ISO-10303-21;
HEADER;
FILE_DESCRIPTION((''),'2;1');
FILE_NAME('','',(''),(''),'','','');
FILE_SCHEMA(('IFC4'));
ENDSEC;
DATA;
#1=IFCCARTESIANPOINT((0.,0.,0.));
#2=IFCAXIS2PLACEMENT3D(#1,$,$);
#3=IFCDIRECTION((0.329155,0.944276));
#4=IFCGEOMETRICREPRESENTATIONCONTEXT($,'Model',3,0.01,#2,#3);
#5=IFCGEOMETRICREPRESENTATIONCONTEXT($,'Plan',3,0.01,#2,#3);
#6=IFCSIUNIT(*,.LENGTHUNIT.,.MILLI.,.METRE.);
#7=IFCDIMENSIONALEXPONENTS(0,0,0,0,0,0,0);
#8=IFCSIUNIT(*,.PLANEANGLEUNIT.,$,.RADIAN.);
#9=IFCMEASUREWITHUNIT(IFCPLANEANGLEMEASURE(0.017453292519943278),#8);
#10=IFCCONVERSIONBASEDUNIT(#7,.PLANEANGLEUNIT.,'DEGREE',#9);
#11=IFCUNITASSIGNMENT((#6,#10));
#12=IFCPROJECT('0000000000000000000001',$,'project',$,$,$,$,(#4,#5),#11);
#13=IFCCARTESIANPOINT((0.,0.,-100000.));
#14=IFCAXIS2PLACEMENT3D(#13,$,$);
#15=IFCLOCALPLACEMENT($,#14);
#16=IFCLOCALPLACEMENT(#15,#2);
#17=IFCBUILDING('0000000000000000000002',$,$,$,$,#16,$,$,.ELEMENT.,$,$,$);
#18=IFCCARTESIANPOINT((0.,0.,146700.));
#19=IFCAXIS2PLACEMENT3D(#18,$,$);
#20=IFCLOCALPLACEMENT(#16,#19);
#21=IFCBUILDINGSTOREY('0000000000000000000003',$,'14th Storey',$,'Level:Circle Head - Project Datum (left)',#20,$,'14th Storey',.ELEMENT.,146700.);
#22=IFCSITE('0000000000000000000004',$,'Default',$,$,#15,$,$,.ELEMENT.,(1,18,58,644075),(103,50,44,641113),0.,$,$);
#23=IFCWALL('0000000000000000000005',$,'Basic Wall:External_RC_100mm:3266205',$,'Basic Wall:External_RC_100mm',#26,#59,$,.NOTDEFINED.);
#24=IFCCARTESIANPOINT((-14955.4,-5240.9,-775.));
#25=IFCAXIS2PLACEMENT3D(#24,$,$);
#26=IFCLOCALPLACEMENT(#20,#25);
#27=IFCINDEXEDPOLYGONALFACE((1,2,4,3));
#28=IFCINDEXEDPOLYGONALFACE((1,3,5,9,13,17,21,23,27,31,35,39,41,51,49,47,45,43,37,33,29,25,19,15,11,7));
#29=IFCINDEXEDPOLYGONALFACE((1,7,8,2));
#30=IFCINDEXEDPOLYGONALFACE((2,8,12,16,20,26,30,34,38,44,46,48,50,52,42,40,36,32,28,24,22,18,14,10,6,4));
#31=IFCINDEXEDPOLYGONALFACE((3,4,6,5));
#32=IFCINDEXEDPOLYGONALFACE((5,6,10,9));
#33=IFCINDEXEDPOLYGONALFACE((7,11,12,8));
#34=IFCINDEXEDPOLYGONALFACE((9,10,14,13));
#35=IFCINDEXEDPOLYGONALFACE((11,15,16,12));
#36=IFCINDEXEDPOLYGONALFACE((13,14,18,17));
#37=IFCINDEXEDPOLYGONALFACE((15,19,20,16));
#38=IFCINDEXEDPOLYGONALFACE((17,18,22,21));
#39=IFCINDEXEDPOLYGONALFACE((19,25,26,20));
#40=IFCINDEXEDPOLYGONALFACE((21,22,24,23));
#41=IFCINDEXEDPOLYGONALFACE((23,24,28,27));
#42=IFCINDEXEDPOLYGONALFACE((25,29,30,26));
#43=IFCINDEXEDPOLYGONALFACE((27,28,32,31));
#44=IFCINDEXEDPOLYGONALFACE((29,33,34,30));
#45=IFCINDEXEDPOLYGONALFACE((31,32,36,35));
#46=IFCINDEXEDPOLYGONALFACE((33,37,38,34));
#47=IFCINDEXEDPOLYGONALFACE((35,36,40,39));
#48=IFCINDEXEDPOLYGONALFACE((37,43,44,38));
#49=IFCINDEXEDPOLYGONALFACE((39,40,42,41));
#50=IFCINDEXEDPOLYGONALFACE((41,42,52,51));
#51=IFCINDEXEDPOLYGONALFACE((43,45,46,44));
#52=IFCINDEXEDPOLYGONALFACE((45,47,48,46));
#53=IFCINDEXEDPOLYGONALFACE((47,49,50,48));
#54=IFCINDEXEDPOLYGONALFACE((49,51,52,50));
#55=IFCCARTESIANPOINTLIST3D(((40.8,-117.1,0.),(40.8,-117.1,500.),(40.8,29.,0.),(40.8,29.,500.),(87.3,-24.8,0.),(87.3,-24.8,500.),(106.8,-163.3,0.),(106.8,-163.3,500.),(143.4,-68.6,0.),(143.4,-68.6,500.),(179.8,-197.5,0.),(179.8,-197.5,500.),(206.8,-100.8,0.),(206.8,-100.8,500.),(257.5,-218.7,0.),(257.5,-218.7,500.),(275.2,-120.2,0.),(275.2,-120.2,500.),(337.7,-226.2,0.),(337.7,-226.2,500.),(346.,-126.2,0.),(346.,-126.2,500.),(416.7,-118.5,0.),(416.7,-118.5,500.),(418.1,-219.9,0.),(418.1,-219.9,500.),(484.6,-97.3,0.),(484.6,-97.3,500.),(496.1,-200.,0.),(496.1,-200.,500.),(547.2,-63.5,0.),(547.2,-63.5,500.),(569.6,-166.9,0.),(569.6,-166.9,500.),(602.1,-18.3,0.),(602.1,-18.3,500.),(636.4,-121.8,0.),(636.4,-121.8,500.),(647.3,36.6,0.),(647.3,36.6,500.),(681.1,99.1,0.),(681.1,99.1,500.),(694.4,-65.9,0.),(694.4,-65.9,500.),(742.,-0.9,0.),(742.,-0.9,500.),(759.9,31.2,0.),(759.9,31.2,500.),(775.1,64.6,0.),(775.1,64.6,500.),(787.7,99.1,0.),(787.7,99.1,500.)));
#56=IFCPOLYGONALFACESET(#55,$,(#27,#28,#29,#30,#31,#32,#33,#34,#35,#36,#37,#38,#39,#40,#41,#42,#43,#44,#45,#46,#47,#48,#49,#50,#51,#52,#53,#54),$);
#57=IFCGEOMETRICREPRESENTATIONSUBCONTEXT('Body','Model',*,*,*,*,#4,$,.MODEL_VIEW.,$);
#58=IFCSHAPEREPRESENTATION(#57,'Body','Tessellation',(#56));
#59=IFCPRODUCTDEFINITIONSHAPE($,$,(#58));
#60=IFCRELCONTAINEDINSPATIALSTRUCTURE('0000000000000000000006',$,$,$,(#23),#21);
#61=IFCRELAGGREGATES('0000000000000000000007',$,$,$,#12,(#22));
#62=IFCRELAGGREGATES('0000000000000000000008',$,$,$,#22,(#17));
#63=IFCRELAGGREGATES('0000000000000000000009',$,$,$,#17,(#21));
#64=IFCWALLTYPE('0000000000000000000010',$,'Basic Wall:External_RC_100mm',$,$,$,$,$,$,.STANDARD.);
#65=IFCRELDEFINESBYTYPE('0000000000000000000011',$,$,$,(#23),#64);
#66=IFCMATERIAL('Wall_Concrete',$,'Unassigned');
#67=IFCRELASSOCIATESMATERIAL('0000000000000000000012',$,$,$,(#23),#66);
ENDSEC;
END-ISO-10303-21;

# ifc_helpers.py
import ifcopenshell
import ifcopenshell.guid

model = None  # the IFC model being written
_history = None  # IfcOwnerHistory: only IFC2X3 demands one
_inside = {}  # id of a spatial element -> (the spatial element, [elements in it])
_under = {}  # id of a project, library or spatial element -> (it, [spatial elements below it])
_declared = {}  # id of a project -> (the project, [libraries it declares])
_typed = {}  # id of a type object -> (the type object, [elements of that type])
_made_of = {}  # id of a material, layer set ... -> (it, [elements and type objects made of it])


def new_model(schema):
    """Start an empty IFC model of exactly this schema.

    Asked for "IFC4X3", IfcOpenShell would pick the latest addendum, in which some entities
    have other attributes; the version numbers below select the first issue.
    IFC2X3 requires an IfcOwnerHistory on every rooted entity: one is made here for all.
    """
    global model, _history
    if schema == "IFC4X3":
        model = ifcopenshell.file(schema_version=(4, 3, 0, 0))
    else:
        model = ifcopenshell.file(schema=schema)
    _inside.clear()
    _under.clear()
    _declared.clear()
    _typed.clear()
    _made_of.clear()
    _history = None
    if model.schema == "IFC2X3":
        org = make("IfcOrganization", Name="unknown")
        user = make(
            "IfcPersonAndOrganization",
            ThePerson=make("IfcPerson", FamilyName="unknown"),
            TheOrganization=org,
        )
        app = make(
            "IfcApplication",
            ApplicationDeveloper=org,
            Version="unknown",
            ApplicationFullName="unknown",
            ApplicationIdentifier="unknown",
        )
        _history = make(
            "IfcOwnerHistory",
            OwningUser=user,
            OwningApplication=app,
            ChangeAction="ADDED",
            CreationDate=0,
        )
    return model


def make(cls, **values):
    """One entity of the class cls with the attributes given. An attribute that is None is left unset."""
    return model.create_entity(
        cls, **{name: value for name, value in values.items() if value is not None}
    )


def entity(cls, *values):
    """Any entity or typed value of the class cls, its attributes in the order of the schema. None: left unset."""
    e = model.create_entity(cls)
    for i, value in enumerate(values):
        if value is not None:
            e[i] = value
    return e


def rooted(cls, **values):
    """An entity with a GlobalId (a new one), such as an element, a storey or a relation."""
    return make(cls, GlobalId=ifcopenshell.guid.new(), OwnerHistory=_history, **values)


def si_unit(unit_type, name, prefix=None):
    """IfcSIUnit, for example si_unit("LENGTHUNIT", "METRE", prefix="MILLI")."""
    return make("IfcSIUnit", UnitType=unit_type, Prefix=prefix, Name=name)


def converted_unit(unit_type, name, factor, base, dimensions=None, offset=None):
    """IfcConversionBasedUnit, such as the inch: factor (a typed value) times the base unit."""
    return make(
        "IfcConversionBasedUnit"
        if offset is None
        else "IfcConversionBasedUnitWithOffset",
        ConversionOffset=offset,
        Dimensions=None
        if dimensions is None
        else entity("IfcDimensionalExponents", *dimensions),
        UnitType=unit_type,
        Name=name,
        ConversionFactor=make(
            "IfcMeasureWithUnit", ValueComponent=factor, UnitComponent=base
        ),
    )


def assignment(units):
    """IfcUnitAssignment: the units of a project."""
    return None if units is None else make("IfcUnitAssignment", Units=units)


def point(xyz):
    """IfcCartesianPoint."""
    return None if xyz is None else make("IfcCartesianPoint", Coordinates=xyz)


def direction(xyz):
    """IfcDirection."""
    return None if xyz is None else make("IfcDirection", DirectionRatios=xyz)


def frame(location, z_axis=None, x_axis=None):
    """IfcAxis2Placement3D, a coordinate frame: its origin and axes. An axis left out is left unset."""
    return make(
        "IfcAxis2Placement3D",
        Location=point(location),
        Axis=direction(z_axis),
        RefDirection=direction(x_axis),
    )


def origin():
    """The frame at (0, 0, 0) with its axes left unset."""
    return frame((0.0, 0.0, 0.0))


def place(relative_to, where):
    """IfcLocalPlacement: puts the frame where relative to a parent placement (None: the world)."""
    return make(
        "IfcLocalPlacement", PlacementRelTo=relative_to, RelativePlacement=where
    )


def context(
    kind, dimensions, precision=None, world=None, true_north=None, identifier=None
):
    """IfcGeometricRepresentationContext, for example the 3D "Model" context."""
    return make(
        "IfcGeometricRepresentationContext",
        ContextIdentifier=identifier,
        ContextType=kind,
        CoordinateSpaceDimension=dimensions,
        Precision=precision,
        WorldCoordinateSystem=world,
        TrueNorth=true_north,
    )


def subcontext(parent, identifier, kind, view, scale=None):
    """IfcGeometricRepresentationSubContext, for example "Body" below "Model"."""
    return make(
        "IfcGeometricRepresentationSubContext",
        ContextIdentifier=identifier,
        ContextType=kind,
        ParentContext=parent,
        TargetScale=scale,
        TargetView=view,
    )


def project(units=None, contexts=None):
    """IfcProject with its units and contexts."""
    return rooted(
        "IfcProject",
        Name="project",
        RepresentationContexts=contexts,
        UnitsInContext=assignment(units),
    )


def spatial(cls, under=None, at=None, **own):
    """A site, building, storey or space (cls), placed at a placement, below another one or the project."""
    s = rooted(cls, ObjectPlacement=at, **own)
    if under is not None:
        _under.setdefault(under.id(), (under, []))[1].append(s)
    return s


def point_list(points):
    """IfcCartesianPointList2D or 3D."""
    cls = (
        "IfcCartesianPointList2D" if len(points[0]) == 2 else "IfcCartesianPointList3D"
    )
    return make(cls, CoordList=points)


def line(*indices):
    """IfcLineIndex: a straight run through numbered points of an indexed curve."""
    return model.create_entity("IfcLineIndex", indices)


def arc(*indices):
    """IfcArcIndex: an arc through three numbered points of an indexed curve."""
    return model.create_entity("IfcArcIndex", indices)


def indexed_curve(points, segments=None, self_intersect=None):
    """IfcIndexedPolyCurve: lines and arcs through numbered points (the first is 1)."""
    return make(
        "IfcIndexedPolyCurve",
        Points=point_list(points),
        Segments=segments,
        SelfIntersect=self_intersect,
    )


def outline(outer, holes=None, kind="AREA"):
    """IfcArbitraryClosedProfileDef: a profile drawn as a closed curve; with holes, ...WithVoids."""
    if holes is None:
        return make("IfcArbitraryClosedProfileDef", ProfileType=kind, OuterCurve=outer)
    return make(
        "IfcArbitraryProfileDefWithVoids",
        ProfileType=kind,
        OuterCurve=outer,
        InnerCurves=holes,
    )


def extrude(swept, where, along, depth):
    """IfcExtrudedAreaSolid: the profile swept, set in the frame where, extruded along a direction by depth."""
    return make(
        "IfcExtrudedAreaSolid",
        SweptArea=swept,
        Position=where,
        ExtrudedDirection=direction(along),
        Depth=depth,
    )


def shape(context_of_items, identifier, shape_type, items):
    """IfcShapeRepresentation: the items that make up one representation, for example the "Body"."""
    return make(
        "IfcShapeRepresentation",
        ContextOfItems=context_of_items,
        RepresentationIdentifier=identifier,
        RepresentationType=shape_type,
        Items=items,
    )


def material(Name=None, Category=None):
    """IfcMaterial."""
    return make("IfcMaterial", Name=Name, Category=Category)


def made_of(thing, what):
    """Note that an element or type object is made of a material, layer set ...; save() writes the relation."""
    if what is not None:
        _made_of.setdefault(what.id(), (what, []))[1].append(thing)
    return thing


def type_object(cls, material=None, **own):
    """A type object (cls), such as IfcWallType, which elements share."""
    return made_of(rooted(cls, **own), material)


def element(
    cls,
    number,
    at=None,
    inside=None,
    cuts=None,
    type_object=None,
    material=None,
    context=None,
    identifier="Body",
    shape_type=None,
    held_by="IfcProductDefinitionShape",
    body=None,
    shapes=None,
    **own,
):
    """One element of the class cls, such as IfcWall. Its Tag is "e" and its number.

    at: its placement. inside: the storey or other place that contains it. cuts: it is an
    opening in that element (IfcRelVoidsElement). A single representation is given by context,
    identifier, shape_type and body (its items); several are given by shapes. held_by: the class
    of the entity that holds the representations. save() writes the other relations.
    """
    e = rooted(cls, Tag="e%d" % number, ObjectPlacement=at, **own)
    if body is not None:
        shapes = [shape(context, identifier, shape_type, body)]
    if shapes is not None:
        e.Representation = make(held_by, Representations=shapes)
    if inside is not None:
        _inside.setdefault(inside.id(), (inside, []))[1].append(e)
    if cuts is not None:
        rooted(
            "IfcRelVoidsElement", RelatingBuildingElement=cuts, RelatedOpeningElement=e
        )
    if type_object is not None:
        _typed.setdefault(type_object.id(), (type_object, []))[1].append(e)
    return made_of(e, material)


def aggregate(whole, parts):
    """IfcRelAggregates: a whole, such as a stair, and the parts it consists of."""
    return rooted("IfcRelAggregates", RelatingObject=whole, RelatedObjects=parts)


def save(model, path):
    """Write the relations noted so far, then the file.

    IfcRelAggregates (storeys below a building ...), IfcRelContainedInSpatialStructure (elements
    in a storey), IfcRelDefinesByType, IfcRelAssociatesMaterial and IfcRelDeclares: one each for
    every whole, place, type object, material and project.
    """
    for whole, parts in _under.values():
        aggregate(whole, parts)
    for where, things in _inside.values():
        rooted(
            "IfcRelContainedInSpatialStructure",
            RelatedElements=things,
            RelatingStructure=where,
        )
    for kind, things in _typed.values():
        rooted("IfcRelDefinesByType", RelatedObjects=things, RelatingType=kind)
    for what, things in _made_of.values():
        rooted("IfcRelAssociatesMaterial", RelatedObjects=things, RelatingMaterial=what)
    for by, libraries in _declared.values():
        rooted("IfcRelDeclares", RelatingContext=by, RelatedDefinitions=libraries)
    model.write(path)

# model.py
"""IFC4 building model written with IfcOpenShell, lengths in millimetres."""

from ifc_helpers import new_model, entity, si_unit, converted_unit, direction, frame, origin, place, context, subcontext, project, spatial, line, arc, indexed_curve, outline, extrude, material, type_object, element, save


model = new_model("IFC4")

# Units and contexts
model_context = context("Model", 3, precision=0.01, world=origin(), true_north=direction((0.329155, 0.944276)))
plan_context = context("Plan", 3, precision=0.01, world=origin(), true_north=direction((0.329155, 0.944276)))
body_context = subcontext(model_context, "Body", "Model", "MODEL_VIEW")
ifc_project = project(units=[si_unit("LENGTHUNIT", "METRE", prefix="MILLI"), converted_unit("PLANEANGLEUNIT", "DEGREE", entity("IfcPlaneAngleMeasure", 0.017453292519943278), si_unit("PLANEANGLEUNIT", "RADIAN"), dimensions=[0, 0, 0, 0, 0, 0, 0])], contexts=[model_context, plan_context])

# Site, building, storey
site_placement = place(None, frame((0.0, 0.0, -100000.0)))
site = spatial("IfcSite", under=ifc_project, at=site_placement, Name="Default", CompositionType="ELEMENT", RefLatitude=(1, 18, 58, 644075), RefLongitude=(103, 50, 44, 641113), RefElevation=0.0)
building_placement = place(site_placement, origin())
building = spatial("IfcBuilding", under=site, at=building_placement, CompositionType="ELEMENT")
storey_placement = place(building_placement, frame((0.0, 0.0, 146700.0)))
storey = spatial("IfcBuildingStorey", under=building, at=storey_placement, Name="14th Storey", ObjectType="Level:Circle Head - Project Datum (left)", LongName="14th Storey", CompositionType="ELEMENT", Elevation=146700.0)

# Wall
ifc_material_1 = material(Name="Wall_Concrete", Category="Unassigned")
wall_type_1 = type_object("IfcWallType", Name="Basic Wall:External_RC_100mm", PredefinedType="STANDARD")
wall_1_placement = place(storey_placement, frame((-14955.4, -5240.9, -775.0)))
element("IfcWall", 1, at=wall_1_placement, inside=storey, type_object=wall_type_1, material=ifc_material_1, Name="Basic Wall:External_RC_100mm:3266205", ObjectType="Basic Wall:External_RC_100mm", PredefinedType="NOTDEFINED", context=body_context, shape_type="SweptSolid", body=[
    extrude(outline(indexed_curve([(681.1, 99.1), (381.6, -124.0), (40.8, 29.0), (40.8, -117.1), (418.1, -219.9), (742.0, -0.9), (767.8, 47.8), (787.7, 99.1)], segments=[arc(1, 2, 3), line(3, 4), arc(4, 5, 6), arc(6, 7, 8), line(8, 1)], self_intersect=False)), origin(), (0.0, 0.0, 1.0), 500.0),
])

save(model, "model.ifc")
